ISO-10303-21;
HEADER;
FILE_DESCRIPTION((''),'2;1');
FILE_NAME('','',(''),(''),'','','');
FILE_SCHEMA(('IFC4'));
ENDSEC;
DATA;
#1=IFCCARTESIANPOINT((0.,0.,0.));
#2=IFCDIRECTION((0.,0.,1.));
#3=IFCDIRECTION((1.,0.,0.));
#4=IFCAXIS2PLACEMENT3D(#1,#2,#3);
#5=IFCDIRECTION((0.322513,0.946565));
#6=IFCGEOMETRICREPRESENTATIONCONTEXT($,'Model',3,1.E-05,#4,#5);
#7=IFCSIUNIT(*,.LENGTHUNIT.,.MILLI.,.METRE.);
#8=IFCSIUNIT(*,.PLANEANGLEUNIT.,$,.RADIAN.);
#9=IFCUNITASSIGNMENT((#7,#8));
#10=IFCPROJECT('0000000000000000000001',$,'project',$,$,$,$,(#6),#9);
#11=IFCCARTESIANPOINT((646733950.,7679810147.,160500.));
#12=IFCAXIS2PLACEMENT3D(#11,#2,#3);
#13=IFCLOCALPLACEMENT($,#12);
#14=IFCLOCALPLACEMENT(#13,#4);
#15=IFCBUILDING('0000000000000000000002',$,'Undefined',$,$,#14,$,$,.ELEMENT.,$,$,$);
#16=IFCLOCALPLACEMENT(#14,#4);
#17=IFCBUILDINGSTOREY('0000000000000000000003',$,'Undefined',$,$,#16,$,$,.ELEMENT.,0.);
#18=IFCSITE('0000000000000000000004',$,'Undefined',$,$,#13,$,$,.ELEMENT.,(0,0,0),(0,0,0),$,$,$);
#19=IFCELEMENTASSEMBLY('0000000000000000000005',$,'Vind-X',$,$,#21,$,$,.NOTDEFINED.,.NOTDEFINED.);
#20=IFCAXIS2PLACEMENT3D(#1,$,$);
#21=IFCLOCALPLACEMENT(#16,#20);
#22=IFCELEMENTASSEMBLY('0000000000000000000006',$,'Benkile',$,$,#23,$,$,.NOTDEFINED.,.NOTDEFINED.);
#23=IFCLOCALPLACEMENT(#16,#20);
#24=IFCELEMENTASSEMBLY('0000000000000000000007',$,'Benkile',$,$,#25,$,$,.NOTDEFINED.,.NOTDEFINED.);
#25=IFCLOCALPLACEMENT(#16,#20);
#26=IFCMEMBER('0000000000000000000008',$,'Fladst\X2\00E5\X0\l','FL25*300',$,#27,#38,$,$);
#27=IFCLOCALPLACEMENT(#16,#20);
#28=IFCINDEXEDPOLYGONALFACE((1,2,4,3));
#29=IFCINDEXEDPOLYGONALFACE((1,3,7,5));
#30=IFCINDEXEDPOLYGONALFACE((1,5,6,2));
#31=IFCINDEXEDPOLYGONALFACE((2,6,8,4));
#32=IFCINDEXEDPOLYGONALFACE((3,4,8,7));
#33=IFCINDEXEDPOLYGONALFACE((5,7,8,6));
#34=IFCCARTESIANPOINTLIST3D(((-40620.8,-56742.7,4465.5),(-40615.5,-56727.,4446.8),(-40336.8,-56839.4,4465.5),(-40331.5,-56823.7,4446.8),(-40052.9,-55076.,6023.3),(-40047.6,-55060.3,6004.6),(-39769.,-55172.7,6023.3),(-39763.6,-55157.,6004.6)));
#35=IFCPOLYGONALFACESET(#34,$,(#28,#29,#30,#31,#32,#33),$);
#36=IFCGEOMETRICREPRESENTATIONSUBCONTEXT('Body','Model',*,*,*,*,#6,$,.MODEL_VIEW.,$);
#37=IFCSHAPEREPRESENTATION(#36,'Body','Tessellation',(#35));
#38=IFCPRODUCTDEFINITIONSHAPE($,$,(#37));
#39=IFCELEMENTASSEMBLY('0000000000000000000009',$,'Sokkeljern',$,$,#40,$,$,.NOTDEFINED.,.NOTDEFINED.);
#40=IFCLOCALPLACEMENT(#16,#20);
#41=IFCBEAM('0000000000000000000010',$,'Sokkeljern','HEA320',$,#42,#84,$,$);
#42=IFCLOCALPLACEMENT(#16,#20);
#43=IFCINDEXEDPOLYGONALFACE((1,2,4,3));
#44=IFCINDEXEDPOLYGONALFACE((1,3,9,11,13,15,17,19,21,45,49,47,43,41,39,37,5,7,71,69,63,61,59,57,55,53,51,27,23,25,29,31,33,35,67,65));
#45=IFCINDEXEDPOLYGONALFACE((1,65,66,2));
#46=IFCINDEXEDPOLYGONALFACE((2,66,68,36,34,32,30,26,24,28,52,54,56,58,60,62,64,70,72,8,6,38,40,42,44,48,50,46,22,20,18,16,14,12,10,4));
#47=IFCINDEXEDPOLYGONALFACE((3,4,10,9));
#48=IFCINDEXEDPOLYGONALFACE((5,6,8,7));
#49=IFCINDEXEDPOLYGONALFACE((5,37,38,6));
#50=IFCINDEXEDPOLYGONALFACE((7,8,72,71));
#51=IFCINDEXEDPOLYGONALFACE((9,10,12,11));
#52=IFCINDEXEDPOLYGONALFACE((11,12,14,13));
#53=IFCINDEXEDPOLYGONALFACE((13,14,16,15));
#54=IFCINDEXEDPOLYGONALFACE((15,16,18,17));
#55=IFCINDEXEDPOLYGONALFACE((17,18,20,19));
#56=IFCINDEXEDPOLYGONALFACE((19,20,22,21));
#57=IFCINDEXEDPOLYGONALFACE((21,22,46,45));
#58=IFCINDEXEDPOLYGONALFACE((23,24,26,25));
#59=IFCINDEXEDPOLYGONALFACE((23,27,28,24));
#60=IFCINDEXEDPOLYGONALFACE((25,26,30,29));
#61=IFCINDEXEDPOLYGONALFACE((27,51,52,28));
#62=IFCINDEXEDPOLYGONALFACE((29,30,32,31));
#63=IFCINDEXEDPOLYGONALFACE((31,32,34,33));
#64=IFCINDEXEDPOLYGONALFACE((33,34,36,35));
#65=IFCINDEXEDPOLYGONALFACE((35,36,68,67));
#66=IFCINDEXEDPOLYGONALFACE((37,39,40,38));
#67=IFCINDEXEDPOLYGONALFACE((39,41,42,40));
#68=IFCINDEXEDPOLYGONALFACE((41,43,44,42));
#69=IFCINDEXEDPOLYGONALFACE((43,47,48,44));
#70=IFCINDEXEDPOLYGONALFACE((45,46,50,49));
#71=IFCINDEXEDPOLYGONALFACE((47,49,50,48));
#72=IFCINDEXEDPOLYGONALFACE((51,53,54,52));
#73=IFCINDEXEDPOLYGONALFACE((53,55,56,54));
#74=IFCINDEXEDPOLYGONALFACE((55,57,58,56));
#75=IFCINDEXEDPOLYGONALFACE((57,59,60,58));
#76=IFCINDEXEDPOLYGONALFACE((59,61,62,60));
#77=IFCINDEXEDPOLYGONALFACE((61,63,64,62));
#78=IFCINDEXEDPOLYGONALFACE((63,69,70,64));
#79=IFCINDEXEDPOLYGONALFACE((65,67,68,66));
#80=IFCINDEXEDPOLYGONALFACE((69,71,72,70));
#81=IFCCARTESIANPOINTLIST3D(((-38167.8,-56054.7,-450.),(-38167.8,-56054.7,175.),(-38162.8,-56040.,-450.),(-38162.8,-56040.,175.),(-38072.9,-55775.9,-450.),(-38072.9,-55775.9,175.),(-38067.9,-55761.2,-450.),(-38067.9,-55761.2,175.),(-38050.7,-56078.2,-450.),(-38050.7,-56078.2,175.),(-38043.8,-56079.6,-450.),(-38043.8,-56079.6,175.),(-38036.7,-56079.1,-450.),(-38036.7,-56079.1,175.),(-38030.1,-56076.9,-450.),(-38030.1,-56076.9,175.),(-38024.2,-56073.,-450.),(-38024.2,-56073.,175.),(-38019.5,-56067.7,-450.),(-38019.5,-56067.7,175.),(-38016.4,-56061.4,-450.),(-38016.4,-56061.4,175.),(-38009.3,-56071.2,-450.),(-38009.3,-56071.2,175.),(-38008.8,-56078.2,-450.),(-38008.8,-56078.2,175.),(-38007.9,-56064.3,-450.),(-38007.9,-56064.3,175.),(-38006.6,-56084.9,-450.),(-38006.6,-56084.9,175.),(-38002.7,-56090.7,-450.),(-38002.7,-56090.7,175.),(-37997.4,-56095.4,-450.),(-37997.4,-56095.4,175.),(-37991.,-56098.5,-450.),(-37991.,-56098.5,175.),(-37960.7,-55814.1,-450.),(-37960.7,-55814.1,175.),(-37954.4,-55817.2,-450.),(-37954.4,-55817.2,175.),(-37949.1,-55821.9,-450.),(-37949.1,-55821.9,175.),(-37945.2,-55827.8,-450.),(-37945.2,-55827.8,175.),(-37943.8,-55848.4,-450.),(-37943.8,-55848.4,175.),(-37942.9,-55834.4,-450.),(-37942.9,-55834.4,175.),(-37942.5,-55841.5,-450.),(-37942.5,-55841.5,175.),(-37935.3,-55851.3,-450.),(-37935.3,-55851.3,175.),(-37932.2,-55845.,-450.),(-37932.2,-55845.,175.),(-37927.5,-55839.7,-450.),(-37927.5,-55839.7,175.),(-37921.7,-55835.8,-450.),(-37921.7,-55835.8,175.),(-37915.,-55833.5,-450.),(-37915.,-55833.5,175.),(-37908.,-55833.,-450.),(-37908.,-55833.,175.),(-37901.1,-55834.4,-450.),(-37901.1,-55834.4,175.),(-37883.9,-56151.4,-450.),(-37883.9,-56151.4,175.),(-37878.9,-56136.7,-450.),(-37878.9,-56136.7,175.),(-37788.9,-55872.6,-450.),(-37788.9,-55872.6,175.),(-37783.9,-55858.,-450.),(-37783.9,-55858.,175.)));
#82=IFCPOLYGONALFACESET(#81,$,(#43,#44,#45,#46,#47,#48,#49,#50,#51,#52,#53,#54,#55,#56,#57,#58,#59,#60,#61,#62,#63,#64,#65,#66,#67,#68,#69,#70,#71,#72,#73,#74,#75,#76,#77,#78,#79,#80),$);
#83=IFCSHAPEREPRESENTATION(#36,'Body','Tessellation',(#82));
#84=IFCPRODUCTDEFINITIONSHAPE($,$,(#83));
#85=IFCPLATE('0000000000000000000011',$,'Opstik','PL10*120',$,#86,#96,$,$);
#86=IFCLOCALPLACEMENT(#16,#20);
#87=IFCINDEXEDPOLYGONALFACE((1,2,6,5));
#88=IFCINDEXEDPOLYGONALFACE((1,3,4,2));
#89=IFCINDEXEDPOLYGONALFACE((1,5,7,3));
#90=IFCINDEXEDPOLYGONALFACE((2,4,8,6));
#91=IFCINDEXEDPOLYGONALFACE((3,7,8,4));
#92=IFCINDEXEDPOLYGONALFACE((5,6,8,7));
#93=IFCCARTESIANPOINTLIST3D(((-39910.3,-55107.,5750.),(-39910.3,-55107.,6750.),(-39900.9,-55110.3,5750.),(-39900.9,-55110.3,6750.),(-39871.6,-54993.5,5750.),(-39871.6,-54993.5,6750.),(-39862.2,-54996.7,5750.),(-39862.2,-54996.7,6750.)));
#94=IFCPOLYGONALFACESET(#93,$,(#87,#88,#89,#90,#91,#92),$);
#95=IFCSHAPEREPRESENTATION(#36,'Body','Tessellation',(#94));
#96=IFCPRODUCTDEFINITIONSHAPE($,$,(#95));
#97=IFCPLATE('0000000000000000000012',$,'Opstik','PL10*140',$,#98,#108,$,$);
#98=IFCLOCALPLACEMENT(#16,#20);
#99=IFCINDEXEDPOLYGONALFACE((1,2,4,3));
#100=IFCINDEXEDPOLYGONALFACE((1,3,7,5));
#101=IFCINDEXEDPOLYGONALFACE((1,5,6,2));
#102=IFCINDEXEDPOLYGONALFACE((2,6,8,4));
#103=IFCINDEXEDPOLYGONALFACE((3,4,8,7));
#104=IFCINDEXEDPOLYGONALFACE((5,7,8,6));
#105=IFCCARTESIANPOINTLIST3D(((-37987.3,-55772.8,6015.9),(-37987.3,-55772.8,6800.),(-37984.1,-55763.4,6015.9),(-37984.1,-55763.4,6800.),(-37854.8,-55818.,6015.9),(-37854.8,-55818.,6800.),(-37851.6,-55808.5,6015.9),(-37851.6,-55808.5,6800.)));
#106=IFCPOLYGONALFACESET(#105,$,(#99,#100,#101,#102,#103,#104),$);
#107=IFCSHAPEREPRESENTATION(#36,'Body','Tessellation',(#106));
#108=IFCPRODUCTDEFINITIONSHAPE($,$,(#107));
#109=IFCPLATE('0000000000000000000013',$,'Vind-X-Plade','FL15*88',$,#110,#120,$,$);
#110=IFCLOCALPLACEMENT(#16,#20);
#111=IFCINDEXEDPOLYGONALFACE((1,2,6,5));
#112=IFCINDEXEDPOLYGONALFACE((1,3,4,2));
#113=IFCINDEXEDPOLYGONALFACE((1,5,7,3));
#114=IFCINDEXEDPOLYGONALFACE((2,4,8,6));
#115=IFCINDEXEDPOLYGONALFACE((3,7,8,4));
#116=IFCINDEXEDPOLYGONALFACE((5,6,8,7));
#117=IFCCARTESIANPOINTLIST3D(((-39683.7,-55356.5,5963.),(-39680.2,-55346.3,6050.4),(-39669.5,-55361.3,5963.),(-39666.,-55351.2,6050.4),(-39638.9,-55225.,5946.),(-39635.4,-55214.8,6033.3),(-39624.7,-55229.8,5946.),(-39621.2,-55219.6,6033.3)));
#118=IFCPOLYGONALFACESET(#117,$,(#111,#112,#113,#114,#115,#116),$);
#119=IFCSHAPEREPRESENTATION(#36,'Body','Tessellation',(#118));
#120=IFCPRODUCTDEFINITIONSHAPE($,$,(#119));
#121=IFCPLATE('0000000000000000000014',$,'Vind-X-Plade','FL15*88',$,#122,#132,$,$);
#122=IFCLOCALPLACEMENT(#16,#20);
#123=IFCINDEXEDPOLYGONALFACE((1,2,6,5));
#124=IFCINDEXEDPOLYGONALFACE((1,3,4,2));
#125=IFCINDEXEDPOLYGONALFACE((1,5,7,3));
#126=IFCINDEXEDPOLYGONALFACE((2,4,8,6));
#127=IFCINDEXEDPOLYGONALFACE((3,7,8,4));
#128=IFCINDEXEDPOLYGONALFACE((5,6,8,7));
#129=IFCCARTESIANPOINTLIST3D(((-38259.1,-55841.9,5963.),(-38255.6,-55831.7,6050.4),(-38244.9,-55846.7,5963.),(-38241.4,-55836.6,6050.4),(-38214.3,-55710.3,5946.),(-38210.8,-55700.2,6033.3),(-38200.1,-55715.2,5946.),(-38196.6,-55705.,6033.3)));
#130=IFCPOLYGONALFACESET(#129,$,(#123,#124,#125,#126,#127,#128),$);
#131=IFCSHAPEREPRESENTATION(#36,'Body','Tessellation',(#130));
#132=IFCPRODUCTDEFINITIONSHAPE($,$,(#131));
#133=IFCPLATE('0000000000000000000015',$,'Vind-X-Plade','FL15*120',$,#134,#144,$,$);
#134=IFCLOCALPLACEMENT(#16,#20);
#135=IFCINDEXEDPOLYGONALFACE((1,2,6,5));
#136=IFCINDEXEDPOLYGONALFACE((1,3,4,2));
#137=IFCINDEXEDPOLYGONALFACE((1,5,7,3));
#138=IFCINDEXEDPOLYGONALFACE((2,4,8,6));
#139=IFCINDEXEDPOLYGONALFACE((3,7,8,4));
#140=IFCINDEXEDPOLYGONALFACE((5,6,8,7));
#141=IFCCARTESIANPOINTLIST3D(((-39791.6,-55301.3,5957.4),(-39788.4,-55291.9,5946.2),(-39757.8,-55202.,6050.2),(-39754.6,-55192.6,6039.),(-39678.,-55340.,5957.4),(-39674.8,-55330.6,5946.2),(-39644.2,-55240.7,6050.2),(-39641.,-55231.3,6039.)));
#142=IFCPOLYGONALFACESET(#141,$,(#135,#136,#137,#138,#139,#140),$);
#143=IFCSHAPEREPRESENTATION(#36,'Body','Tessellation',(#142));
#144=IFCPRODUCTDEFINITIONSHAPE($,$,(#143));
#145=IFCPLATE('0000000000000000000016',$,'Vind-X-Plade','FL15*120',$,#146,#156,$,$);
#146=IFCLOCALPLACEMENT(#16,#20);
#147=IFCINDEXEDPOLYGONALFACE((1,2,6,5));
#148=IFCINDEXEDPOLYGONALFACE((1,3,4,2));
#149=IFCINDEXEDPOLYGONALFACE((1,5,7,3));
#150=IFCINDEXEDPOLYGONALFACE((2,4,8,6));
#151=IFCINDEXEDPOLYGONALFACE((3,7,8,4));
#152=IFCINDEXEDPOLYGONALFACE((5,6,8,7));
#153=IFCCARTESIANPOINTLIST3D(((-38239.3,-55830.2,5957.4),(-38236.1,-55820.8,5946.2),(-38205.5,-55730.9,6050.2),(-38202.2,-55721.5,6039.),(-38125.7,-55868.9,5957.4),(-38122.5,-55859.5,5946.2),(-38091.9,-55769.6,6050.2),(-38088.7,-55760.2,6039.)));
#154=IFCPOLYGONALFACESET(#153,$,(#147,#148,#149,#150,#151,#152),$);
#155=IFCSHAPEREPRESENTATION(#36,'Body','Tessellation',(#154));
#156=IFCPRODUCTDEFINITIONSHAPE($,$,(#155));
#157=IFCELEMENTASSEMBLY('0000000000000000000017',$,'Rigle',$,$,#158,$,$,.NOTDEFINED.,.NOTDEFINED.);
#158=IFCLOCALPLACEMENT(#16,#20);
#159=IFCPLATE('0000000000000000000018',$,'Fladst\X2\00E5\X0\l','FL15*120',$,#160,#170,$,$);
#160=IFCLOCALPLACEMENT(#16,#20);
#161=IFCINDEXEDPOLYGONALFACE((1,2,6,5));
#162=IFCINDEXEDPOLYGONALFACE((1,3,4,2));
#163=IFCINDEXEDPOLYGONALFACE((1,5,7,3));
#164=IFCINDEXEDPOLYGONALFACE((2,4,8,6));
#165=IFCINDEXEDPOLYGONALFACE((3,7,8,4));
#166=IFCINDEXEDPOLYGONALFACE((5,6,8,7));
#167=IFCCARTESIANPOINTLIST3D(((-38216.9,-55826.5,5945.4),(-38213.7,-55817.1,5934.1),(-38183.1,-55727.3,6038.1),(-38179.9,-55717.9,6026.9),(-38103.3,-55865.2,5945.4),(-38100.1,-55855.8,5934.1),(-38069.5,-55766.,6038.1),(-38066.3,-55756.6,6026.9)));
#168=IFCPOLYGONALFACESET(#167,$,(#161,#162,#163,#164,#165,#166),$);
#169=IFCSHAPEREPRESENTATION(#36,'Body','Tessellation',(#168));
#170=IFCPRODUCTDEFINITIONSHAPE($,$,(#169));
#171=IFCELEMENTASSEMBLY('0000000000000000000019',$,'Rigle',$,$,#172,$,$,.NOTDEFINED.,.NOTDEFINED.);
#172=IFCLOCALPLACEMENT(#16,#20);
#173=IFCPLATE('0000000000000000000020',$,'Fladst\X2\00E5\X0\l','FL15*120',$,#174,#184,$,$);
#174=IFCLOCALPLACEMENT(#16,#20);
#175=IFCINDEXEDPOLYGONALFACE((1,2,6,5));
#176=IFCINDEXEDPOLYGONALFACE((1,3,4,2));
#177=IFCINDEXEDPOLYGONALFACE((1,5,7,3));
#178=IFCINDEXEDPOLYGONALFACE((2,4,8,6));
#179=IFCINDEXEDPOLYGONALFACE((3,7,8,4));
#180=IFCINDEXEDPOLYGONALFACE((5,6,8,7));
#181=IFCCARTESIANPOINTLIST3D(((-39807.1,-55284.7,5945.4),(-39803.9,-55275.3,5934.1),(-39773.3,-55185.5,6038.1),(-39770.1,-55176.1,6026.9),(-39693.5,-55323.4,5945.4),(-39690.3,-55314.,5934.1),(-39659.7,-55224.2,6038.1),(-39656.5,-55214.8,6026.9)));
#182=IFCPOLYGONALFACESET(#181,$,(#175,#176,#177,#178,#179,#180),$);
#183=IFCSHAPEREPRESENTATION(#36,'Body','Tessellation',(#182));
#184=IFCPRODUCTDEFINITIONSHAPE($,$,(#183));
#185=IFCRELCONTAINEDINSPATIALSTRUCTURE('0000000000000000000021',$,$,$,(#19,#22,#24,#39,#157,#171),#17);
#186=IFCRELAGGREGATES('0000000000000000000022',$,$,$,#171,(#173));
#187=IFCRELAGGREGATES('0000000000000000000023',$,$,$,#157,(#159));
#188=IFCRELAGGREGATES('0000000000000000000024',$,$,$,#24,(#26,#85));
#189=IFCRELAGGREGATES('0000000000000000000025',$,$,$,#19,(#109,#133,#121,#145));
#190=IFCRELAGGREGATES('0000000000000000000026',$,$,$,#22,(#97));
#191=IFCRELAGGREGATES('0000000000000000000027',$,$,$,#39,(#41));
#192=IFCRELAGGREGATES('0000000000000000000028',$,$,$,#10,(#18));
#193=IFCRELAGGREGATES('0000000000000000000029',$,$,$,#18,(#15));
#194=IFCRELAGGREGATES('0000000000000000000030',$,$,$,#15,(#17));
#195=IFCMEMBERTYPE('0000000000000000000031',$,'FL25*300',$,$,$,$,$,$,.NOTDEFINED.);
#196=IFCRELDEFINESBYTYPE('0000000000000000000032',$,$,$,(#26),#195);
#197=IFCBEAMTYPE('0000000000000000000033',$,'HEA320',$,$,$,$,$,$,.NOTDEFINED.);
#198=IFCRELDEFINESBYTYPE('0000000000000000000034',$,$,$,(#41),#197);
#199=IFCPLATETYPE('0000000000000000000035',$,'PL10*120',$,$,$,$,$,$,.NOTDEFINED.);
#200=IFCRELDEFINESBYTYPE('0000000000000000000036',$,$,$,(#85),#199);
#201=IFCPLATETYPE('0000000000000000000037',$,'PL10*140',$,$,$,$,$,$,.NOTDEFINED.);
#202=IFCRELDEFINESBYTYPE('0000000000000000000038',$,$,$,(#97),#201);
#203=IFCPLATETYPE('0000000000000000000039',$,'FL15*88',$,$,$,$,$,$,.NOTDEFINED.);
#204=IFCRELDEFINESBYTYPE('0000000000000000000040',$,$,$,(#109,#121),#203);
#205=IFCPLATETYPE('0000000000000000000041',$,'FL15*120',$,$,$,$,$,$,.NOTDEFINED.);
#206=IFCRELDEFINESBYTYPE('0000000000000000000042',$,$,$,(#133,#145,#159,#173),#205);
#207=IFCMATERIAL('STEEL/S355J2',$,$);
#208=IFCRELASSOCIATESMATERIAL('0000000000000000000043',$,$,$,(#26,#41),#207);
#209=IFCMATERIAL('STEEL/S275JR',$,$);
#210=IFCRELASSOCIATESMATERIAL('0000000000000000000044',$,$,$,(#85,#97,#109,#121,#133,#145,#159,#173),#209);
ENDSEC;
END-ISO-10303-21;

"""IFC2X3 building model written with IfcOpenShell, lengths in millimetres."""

from ifc_helpers import new_model, si_unit, direction, frame, origin_with_axes, origin_2d_with_axis, place, context, subcontext, project, spatial, polyline, rectangle, i_section, outline, extrude, material, type_object, element, aggregate, save


model = new_model("IFC2X3")

# Units and contexts
model_context = context("Model", 3, precision=1e-05, world=origin_with_axes(), true_north=direction((0.322513, 0.946565)))
body_context = subcontext(model_context, "Body", "Model", "MODEL_VIEW")
ifc_project = project(units=[si_unit("LENGTHUNIT", "METRE", prefix="MILLI"), si_unit("PLANEANGLEUNIT", "RADIAN")], contexts=[model_context])

# Site, building, storey
site_placement = place(None, frame((646733950.0, 7679810147.0, 160500.0), z_axis=(0.0, 0.0, 1.0), x_axis=(1.0, 0.0, 0.0)))
site = spatial("IfcSite", under=ifc_project, at=site_placement, Name="Undefined", CompositionType="ELEMENT", RefLatitude=(0, 0, 0), RefLongitude=(0, 0, 0))
building_placement = place(site_placement, origin_with_axes())
building = spatial("IfcBuilding", under=site, at=building_placement, Name="Undefined", CompositionType="ELEMENT")
storey_placement = place(building_placement, origin_with_axes())
storey = spatial("IfcBuildingStorey", under=building, at=storey_placement, Name="Undefined", CompositionType="ELEMENT", Elevation=0.0)

# Element assembly
assembly_1_placement = place(storey_placement, origin_with_axes())
assembly_1 = element("IfcElementAssembly", 1, at=assembly_1_placement, inside=storey, Name="Vind-X", AssemblyPlace="NOTDEFINED", PredefinedType="NOTDEFINED")

# Element assemblies, member
assembly_2_placement = place(storey_placement, origin_with_axes())
assembly_2 = element("IfcElementAssembly", 2, at=assembly_2_placement, inside=storey, Name="Benkile", AssemblyPlace="NOTDEFINED", PredefinedType="NOTDEFINED")
ifc_material_1 = material(Name="STEEL/S355J2")
member_type = type_object("IfcMemberType", Name="FL25*300", PredefinedType="NOTDEFINED")
assembly_3_placement = place(storey_placement, origin_with_axes())
assembly_3 = element("IfcElementAssembly", 3, at=assembly_3_placement, inside=storey, Name="Benkile", AssemblyPlace="NOTDEFINED", PredefinedType="NOTDEFINED")
member_1_placement = place(assembly_3_placement, frame((-39908.3, -55116.5, 6014.0), z_axis=(-0.946565, 0.322513, 0.0), x_axis=(-0.241548, -0.708935, -0.66262)))
member_1 = element("IfcMember", 4, at=member_1_placement, type_object=member_type, material=ifc_material_1, Name="Fladstål", Description="FL25*300", context=body_context, shape_type="SweptSolid", body=[
    extrude(rectangle(XDim=25.0, YDim=300.0, at=origin_2d_with_axis()), frame((2351.0, 0.0, 0.0), z_axis=(-1.0, 0.0, 0.0), x_axis=(0.0, -1.0, 0.0)), (0.0, 0.0, 1.0), 2351.0),
])

# Element assembly, beam
assembly_4_placement = place(storey_placement, origin_with_axes())
assembly_4 = element("IfcElementAssembly", 5, at=assembly_4_placement, inside=storey, Name="Sokkeljern", AssemblyPlace="NOTDEFINED", PredefinedType="NOTDEFINED")
beam_type_1 = type_object("IfcBeamType", Name="HEA320", PredefinedType="NOTDEFINED")
beam_1_placement = place(assembly_4_placement, frame((-37975.9, -55956.3, 175.0), z_axis=(-0.322513, -0.946565, 0.0), x_axis=(0.0, 0.0, -1.0)))
beam_1 = element("IfcBeam", 6, at=beam_1_placement, type_object=beam_type_1, material=ifc_material_1, Name="Sokkeljern", Description="HEA320", context=body_context, shape_type="SweptSolid", body=[
    extrude(i_section(OverallWidth=300.0, OverallDepth=310.0, WebThickness=9.0, FlangeThickness=15.5, FilletRadius=27.0, at=origin_2d_with_axis()), frame((625.0, 0.0, 0.0), z_axis=(-1.0, 0.0, 0.0), x_axis=(0.0, -1.0, 0.0)), (0.0, 0.0, 1.0), 625.0),
])

# Plates
ifc_material_2 = material(Name="STEEL/S275JR")
plate_type_1 = type_object("IfcPlateType", Name="PL10*120", PredefinedType="NOTDEFINED")
plate_1_placement = place(assembly_3_placement, frame((-39905.6, -55108.7, 5750.0), z_axis=(-0.946565, 0.322513, 0.0), x_axis=(0.0, 0.0, 1.0)))
plate_1 = element("IfcPlate", 7, at=plate_1_placement, type_object=plate_type_1, material=ifc_material_2, Name="Opstik", Description="PL10*120", context=body_context, shape_type="SweptSolid", body=[
    extrude(outline(polyline([(0.0, 0.0), (1000.0, 0.0), (1000.0, 120.0), (1000.0, 120.0), (0.0, 120.0), (0.0, 120.0), (0.0, 0.0)])), frame((0.0, 0.0, -5.0), z_axis=(0.0, 0.0, 1.0), x_axis=(1.0, 0.0, 0.0)), (0.0, 0.0, 1.0), 10.0),
])
plate_type_2 = type_object("IfcPlateType", Name="PL10*140", PredefinedType="NOTDEFINED")
plate_2_placement = place(assembly_2_placement, frame((-37985.7, -55768.1, 6015.9), z_axis=(0.322513, 0.946565, 0.0), x_axis=(0.0, 0.0, 1.0)))
plate_2 = element("IfcPlate", 8, at=plate_2_placement, type_object=plate_type_2, material=ifc_material_2, Name="Opstik", Description="PL10*140", context=body_context, shape_type="SweptSolid", body=[
    extrude(outline(polyline([(0.0, 0.0), (784.1, 0.0), (784.1, 0.0), (784.1, 140.0), (784.1, 140.0), (0.0, 140.0), (0.0, 0.0)])), frame((0.0, 0.0, -5.0), z_axis=(0.0, 0.0, 1.0), x_axis=(1.0, 0.0, 0.0)), (0.0, 0.0, 1.0), 10.0),
])
plate_type_3 = type_object("IfcPlateType", Name="FL15*88", PredefinedType="NOTDEFINED")
plate_3_placement = place(assembly_1_placement, frame((-39676.6, -55358.9, 5963.0), z_axis=(0.946565, -0.322513, 0.0), x_axis=(0.320109, 0.93951, -0.121869)))
plate_3 = element("IfcPlate", 9, at=plate_3_placement, type_object=plate_type_3, material=ifc_material_2, Name="Vind-X-Plade", Description="FL15*88", context=body_context, shape_type="SweptSolid", body=[
    extrude(outline(polyline([(0.0, 0.0), (140.0, 0.0), (140.0, 88.0), (0.0, 88.0), (0.0, 0.0)])), frame((0.0, 0.0, -7.5), z_axis=(0.0, 0.0, 1.0), x_axis=(1.0, 0.0, 0.0)), (0.0, 0.0, 1.0), 15.0),
])
plate_4_placement = place(assembly_1_placement, frame((-38252.0, -55844.3, 5963.0), z_axis=(0.946565, -0.322513, 0.0), x_axis=(0.320109, 0.93951, -0.121869)))
plate_4 = element("IfcPlate", 10, at=plate_4_placement, type_object=plate_type_3, material=ifc_material_2, Name="Vind-X-Plade", Description="FL15*88", context=body_context, shape_type="SweptSolid", body=[
    extrude(outline(polyline([(0.0, 0.0), (140.0, 0.0), (140.0, 88.0), (0.0, 88.0), (0.0, 0.0)])), frame((0.0, 0.0, -7.5), z_axis=(0.0, 0.0, 1.0), x_axis=(1.0, 0.0, 0.0)), (0.0, 0.0, 1.0), 15.0),
])
plate_type_4 = type_object("IfcPlateType", Name="FL15*120", PredefinedType="NOTDEFINED")
plate_5_placement = place(assembly_1_placement, frame((-39773.1, -55246.9, 5998.2), z_axis=(-0.213703, -0.627213, 0.748956), x_axis=(0.946565, -0.322513, 0.0)))
plate_5 = element("IfcPlate", 11, at=plate_5_placement, type_object=plate_type_4, material=ifc_material_2, Name="Vind-X-Plade", Description="FL15*120", context=body_context, shape_type="SweptSolid", body=[
    extrude(outline(polyline([(0.0, -70.0), (0.0, 70.0), (120.0, 70.0), (120.0, -70.0), (0.0, -70.0)])), frame((0.0, 0.0, -7.5), z_axis=(0.0, 0.0, 1.0), x_axis=(1.0, 0.0, 0.0)), (0.0, 0.0, 1.0), 15.0),
])
plate_6_placement = place(assembly_1_placement, frame((-38107.2, -55814.6, 5998.2), z_axis=(0.213703, 0.627213, -0.748956), x_axis=(-0.946565, 0.322513, 0.0)))
plate_6 = element("IfcPlate", 12, at=plate_6_placement, type_object=plate_type_4, material=ifc_material_2, Name="Vind-X-Plade", Description="FL15*120", context=body_context, shape_type="SweptSolid", body=[
    extrude(outline(polyline([(0.0, -70.0), (0.0, 70.0), (120.0, 70.0), (120.0, -70.0), (0.0, -70.0)])), frame((0.0, 0.0, -7.5), z_axis=(0.0, 0.0, 1.0), x_axis=(1.0, 0.0, 0.0)), (0.0, 0.0, 1.0), 15.0),
])

# Element assemblies, plates
assembly_5_placement = place(storey_placement, origin_with_axes())
assembly_5 = element("IfcElementAssembly", 13, at=assembly_5_placement, inside=storey, Name="Rigle", AssemblyPlace="NOTDEFINED", PredefinedType="NOTDEFINED")
plate_7_placement = place(assembly_5_placement, frame((-38101.7, -55860.5, 5939.7), z_axis=(-0.213703, -0.627213, 0.748956), x_axis=(0.241548, 0.708935, 0.66262)))
plate_7 = element("IfcPlate", 14, at=plate_7_placement, type_object=plate_type_4, material=ifc_material_2, Name="Fladstål", Description="FL15*120", context=body_context, shape_type="SweptSolid", body=[
    extrude(outline(polyline([(0.0, 0.0), (140.0, 0.0), (140.0, 120.0), (0.0, 120.0), (0.0, 0.0)])), frame((0.0, 0.0, -7.5), z_axis=(0.0, 0.0, 1.0), x_axis=(1.0, 0.0, 0.0)), (0.0, 0.0, 1.0), 15.0),
])
assembly_6_placement = place(storey_placement, origin_with_axes())
assembly_6 = element("IfcElementAssembly", 15, at=assembly_6_placement, inside=storey, Name="Rigle", AssemblyPlace="NOTDEFINED", PredefinedType="NOTDEFINED")
plate_8_placement = place(assembly_6_placement, frame((-39805.5, -55280.0, 5939.7), z_axis=(0.213703, 0.627213, -0.748956), x_axis=(0.241548, 0.708935, 0.66262)))
plate_8 = element("IfcPlate", 16, at=plate_8_placement, type_object=plate_type_4, material=ifc_material_2, Name="Fladstål", Description="FL15*120", context=body_context, shape_type="SweptSolid", body=[
    extrude(outline(polyline([(0.0, 0.0), (140.0, 0.0), (140.0, 120.0), (0.0, 120.0), (0.0, 0.0)])), frame((0.0, 0.0, -7.5), z_axis=(0.0, 0.0, 1.0), x_axis=(1.0, 0.0, 0.0)), (0.0, 0.0, 1.0), 15.0),
])
aggregate(assembly_6, [plate_8])

aggregate(assembly_5, [plate_7])
aggregate(assembly_3, [member_1, plate_1])

aggregate(assembly_1, [plate_3, plate_5, plate_4, plate_6])
aggregate(assembly_2, [plate_2])
aggregate(assembly_4, [beam_1])

save(model, "model.ifc")
